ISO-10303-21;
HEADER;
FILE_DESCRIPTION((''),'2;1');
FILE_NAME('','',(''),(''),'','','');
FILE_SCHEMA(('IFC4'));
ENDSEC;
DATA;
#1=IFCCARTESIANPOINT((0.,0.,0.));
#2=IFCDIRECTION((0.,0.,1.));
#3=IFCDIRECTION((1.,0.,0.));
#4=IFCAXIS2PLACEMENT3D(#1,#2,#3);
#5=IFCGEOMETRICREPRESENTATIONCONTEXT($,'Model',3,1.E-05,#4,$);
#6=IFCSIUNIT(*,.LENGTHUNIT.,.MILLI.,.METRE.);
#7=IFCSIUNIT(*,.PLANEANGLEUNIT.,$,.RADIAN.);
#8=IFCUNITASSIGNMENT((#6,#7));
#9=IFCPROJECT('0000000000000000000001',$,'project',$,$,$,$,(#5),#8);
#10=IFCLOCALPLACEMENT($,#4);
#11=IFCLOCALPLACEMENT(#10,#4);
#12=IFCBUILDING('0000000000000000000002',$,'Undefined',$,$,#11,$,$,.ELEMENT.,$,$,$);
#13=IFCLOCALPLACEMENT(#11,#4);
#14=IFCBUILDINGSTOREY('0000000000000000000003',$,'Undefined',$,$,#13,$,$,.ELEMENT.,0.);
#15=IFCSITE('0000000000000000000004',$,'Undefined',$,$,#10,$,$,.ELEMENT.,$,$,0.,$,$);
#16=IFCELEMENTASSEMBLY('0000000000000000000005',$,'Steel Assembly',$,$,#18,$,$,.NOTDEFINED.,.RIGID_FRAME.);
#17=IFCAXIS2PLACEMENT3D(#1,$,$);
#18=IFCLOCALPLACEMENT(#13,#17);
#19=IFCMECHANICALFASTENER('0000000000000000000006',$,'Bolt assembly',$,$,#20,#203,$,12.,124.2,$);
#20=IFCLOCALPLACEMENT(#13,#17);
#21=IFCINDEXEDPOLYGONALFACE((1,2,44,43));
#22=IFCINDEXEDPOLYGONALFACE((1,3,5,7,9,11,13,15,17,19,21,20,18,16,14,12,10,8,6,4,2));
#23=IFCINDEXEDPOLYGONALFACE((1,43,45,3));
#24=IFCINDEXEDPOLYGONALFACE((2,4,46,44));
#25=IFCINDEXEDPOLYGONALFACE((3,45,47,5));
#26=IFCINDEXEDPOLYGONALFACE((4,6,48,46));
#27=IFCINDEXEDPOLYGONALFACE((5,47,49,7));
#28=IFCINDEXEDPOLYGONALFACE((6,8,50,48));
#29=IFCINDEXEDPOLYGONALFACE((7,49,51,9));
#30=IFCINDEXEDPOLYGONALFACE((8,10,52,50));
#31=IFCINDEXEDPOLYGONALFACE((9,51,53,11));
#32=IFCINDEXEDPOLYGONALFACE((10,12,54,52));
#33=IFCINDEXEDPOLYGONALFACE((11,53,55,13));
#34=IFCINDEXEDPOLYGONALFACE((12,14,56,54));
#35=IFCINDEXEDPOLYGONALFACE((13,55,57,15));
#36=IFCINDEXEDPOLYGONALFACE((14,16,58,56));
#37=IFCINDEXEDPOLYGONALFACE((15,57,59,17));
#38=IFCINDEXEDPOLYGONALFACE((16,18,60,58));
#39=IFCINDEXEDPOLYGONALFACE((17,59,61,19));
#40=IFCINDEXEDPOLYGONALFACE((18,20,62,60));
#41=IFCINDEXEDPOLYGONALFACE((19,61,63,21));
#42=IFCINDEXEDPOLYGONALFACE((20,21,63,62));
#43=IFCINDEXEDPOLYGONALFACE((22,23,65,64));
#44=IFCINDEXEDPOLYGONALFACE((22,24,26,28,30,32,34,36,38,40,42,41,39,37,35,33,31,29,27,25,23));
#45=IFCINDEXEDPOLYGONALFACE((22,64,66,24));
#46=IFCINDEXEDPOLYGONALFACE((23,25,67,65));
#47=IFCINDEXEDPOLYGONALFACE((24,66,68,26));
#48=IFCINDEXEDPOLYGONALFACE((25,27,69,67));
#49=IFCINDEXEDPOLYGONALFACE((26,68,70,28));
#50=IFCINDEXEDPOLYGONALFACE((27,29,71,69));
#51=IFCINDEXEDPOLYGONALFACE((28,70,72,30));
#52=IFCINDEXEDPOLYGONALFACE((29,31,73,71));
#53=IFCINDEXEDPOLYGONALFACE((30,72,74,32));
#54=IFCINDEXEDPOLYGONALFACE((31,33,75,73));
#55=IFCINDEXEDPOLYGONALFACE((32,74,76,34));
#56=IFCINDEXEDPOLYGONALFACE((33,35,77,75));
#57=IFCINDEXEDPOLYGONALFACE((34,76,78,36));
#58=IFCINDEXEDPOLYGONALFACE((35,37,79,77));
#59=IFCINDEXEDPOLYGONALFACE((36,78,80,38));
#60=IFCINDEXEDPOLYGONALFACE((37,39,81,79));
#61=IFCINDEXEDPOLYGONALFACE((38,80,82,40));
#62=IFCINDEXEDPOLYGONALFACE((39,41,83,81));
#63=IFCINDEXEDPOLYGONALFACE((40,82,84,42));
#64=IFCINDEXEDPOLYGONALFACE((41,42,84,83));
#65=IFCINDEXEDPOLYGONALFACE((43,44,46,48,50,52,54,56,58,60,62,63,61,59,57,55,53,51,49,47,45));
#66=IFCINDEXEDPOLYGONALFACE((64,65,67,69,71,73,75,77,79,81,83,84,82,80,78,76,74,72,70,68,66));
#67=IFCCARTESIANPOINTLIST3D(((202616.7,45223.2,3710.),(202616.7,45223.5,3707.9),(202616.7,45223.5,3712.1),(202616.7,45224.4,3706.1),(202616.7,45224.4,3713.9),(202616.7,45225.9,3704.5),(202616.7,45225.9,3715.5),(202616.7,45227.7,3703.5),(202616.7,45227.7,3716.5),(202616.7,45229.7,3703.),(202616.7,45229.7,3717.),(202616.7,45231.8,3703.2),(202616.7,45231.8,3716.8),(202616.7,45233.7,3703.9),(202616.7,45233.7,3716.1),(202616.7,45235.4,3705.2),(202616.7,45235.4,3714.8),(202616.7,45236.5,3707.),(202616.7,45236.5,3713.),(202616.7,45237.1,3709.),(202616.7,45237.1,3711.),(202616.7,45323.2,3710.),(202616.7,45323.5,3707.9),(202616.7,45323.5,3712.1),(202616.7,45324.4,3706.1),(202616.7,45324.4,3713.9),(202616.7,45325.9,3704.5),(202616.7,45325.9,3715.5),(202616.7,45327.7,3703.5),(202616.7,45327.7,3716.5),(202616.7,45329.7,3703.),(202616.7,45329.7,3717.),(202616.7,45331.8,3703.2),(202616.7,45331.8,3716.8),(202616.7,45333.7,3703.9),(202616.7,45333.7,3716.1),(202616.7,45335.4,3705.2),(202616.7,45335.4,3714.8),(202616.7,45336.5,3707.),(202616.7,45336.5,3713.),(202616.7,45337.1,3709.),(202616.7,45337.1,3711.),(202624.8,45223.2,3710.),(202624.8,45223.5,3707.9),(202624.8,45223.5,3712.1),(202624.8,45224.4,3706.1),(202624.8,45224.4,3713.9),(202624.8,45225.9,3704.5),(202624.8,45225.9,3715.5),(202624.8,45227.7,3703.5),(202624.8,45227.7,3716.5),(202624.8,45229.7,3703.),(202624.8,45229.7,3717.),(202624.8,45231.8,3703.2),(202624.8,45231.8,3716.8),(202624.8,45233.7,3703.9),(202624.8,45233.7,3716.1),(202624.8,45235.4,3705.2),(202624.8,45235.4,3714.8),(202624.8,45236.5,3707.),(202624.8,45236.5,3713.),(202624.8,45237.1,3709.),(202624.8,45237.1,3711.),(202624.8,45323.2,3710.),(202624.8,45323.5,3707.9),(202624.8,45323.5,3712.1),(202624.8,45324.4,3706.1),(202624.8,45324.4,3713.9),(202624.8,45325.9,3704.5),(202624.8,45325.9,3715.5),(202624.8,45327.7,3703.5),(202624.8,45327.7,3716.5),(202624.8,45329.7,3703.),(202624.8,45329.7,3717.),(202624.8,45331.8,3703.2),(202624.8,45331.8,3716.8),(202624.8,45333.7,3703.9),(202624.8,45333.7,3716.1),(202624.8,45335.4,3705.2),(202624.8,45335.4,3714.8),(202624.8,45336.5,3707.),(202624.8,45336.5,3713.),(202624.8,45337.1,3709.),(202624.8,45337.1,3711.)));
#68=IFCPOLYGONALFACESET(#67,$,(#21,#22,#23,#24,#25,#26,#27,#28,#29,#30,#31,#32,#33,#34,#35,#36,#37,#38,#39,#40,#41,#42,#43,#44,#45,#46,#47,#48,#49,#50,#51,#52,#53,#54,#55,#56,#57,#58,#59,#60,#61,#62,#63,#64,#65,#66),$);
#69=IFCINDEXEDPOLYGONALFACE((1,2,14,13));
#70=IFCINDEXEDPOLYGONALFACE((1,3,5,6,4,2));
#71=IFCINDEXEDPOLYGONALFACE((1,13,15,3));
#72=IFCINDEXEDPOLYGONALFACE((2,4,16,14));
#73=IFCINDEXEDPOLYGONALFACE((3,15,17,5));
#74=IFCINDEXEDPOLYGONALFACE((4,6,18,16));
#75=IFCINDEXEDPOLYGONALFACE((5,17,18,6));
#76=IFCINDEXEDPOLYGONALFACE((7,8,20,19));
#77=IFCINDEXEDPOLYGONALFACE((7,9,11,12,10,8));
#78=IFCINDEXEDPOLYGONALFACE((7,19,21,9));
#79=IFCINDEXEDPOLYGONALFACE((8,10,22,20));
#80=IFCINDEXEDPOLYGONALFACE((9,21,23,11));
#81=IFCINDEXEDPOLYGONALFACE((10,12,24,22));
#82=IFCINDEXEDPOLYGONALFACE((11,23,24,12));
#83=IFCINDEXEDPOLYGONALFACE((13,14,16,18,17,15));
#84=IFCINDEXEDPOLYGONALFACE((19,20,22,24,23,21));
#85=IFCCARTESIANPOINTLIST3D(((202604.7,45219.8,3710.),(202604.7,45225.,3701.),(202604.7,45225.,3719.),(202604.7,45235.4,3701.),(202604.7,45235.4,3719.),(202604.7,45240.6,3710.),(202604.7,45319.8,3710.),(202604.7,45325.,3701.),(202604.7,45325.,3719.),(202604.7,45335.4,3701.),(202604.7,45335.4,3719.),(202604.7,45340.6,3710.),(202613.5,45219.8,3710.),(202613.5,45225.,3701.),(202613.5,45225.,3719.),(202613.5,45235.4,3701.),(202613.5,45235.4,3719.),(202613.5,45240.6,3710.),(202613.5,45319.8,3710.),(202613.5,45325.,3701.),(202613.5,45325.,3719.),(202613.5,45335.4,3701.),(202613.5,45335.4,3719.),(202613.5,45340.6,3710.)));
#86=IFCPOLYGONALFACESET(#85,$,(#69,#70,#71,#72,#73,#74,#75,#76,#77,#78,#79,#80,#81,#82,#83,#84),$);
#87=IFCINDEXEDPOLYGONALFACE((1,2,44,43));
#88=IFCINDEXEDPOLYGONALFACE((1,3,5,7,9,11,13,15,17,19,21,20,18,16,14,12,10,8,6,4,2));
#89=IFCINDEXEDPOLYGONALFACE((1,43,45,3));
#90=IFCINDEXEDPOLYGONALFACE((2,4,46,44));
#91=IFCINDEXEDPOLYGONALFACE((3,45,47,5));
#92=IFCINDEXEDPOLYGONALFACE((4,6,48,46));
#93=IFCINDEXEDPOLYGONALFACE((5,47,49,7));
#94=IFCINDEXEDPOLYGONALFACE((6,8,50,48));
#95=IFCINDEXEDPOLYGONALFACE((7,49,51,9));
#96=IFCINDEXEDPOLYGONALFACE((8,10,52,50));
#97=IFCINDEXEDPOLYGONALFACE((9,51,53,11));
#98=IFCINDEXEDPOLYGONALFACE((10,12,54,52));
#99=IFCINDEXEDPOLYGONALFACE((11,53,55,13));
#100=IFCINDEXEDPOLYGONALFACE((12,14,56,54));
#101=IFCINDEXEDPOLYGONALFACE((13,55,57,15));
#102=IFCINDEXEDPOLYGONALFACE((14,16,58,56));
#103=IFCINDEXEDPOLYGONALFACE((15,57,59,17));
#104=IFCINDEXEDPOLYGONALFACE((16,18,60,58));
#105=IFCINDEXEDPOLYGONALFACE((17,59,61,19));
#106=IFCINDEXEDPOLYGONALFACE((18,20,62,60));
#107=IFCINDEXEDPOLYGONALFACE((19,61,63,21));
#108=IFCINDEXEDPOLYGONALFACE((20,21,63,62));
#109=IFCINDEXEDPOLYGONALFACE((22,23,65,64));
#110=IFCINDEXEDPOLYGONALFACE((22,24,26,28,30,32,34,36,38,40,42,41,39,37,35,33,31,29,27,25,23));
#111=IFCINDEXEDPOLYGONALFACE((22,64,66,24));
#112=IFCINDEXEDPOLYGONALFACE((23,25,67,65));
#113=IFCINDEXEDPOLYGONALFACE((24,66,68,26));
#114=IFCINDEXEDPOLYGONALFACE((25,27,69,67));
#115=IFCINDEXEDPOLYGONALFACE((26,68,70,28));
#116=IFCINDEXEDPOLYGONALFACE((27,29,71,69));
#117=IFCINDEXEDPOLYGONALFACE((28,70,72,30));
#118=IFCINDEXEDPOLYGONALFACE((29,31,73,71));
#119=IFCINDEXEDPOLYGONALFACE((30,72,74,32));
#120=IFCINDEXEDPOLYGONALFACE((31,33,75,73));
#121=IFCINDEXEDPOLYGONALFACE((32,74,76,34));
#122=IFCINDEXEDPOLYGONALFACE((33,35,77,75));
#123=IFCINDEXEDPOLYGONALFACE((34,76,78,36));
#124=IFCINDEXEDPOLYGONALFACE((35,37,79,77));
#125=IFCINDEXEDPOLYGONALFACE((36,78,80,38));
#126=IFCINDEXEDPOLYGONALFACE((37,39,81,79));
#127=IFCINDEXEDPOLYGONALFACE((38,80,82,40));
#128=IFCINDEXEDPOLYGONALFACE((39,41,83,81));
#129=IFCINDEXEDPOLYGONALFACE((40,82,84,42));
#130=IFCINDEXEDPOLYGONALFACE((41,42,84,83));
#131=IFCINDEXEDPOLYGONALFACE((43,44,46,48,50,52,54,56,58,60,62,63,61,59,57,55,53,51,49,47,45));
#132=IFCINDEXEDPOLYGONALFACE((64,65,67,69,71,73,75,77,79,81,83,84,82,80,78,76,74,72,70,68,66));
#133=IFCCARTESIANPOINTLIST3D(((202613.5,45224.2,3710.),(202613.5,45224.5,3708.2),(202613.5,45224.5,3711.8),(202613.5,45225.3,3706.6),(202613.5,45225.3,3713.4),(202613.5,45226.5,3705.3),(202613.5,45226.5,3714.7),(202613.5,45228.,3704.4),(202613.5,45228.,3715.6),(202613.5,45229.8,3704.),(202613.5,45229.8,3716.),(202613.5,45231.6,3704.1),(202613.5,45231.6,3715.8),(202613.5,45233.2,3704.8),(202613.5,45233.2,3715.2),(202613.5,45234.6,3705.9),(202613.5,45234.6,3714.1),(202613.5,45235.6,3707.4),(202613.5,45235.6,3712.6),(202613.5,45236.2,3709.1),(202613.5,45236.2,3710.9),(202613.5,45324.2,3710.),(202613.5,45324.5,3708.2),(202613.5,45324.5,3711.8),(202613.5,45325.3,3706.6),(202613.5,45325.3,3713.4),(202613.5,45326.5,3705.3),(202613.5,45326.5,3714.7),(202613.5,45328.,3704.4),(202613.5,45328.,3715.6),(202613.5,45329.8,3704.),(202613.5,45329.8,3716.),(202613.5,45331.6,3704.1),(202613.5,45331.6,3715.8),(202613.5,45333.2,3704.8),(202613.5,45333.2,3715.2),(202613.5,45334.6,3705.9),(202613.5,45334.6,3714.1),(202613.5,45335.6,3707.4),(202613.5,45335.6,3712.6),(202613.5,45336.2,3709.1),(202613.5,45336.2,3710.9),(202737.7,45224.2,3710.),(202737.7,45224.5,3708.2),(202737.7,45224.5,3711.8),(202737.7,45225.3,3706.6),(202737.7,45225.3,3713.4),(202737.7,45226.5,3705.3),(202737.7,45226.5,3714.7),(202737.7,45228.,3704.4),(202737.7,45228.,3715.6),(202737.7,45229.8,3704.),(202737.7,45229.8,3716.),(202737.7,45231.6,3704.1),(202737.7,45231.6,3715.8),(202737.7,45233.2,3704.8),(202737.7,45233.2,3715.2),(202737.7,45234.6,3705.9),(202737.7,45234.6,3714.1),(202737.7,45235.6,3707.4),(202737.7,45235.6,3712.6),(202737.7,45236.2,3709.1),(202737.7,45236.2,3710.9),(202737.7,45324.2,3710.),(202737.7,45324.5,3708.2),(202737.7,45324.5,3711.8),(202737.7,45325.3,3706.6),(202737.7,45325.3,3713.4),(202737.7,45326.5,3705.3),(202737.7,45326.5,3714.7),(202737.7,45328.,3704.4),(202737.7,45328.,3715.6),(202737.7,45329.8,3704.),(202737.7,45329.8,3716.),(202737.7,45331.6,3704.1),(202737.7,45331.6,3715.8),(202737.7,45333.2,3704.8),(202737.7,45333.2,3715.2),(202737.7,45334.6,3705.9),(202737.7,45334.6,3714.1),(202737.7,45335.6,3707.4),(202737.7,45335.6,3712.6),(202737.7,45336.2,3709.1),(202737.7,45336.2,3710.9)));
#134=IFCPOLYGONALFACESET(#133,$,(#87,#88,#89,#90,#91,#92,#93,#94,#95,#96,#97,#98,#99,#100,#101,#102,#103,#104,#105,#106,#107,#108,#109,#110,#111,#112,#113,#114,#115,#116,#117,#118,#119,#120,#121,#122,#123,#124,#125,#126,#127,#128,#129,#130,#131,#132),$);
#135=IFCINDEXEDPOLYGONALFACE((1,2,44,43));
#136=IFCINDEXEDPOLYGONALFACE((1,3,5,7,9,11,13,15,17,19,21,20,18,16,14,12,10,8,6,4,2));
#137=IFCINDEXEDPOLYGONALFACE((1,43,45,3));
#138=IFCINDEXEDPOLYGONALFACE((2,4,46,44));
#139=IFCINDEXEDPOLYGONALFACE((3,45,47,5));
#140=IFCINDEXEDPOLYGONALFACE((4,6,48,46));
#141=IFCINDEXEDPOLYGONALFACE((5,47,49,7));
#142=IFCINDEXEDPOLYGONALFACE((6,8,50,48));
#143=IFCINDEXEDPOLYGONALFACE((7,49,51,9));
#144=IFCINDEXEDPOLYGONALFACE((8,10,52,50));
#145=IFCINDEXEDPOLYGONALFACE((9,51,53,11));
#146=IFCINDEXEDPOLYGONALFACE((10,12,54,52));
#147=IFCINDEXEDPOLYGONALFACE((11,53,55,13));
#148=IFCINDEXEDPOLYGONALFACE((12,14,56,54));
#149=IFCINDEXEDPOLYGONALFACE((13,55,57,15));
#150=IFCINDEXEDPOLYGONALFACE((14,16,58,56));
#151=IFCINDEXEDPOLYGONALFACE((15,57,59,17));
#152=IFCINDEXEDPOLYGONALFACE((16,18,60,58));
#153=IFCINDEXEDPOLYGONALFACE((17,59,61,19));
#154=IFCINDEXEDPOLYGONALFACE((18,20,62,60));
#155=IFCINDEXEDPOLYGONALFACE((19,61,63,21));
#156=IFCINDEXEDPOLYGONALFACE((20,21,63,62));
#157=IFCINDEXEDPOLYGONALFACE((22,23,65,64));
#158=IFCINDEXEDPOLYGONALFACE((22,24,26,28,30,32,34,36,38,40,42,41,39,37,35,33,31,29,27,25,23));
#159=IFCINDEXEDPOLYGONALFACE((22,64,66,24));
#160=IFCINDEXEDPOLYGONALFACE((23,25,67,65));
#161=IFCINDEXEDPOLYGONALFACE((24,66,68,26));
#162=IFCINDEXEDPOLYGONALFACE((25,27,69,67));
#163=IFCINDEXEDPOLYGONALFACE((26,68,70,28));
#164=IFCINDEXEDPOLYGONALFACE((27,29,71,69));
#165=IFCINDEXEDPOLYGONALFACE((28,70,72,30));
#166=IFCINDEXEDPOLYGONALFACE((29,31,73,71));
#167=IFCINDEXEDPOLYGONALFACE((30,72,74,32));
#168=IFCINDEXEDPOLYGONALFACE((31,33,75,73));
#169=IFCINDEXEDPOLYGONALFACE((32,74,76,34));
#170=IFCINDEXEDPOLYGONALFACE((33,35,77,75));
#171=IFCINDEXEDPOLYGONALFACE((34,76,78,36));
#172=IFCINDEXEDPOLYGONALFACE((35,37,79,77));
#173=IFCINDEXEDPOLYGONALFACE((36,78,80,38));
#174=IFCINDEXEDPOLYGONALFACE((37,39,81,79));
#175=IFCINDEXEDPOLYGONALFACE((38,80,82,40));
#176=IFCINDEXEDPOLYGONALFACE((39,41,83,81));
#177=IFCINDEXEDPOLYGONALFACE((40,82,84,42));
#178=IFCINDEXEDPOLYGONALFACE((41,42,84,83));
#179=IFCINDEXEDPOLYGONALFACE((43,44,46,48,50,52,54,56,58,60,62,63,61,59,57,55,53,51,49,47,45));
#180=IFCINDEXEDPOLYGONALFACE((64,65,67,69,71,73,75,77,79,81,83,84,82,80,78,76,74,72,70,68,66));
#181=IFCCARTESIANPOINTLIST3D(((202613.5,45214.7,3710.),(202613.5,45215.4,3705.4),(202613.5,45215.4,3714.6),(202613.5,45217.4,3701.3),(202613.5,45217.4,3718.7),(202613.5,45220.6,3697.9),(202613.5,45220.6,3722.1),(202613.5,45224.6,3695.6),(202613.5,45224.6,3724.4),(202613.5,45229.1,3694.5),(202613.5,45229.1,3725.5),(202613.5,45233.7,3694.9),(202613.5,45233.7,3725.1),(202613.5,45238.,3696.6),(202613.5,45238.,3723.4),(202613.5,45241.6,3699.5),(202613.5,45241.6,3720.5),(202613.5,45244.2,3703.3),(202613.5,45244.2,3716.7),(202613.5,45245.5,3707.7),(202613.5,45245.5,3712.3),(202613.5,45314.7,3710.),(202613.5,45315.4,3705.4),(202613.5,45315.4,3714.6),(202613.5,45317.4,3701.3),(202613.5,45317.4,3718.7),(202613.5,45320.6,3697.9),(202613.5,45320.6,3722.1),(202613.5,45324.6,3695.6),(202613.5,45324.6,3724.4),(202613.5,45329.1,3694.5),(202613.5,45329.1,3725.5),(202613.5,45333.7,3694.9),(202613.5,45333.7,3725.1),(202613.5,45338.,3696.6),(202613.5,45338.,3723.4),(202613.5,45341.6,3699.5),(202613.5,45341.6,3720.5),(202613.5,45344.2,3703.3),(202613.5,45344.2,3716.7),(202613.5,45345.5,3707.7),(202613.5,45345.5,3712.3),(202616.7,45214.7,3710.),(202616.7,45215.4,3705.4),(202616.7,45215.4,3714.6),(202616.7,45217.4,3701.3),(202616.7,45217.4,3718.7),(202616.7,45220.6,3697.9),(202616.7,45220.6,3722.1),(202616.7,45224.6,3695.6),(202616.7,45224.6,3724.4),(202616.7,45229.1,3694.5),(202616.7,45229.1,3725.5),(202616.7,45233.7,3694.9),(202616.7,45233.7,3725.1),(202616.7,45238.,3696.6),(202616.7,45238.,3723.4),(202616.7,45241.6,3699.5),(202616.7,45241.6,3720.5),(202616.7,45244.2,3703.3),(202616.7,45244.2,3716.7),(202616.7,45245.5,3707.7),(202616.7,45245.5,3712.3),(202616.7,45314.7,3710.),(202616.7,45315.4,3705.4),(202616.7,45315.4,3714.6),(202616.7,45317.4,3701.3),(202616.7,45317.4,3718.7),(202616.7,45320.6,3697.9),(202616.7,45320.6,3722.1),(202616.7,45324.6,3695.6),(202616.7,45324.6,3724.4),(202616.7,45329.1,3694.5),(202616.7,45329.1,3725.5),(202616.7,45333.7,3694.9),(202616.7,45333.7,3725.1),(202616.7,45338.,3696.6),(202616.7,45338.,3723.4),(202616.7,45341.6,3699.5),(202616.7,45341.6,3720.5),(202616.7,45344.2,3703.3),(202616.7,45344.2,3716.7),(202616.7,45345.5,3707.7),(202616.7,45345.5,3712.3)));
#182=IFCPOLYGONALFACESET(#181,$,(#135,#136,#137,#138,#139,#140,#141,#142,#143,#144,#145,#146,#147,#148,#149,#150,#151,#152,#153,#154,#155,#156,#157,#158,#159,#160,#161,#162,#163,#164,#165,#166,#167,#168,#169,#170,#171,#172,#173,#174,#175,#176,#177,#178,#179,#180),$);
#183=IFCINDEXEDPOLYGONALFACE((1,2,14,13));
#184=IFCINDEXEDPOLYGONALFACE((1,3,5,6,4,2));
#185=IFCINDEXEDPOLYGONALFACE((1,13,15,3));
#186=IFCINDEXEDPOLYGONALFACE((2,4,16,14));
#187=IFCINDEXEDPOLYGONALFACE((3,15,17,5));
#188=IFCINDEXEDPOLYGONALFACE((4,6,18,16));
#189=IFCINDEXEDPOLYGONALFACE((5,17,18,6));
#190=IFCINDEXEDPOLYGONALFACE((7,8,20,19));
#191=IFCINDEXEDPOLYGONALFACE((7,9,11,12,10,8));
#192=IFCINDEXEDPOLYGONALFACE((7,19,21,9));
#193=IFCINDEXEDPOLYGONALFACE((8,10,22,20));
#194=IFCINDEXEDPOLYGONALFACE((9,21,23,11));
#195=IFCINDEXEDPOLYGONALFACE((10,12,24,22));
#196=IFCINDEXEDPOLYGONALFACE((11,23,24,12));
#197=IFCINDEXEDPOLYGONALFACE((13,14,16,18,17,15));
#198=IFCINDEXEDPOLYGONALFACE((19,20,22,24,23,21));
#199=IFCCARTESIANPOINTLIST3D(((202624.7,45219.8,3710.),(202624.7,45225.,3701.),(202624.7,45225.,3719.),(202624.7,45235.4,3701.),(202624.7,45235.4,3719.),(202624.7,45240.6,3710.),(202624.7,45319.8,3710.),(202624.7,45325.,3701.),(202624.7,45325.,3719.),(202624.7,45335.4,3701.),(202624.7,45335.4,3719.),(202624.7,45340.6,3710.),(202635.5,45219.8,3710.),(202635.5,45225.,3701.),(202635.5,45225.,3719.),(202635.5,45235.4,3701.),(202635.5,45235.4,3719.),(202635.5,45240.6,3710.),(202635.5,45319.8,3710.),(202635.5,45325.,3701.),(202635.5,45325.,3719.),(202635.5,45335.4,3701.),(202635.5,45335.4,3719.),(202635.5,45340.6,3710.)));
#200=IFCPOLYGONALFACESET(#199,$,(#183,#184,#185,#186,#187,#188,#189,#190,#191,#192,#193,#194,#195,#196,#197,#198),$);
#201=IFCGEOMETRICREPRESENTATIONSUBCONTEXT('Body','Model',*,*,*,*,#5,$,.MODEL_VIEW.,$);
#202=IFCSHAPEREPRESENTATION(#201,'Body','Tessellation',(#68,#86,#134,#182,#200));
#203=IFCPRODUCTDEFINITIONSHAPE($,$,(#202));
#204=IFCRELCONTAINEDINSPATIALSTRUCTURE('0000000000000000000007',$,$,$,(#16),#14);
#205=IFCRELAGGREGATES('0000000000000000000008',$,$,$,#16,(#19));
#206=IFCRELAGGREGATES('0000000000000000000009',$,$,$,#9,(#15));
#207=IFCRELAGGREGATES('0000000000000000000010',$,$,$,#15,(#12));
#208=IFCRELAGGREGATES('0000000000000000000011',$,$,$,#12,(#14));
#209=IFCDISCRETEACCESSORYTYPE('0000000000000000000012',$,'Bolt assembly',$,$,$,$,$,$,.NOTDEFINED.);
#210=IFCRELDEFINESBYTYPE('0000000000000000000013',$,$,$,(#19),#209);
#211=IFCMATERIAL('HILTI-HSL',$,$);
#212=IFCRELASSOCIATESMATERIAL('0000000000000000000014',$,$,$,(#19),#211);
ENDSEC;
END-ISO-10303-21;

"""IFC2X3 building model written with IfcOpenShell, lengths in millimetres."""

from ifc_helpers import new_model, si_unit, frame, origin_with_axes, origin_2d_with_axis, place, context, subcontext, project, spatial, polyline, circle, outline, extrude, source, transform, mapped, material, type_object, element, aggregate, save


model = new_model("IFC2X3")

# Units and contexts
model_context = context("Model", 3, precision=1e-05, world=origin_with_axes())
body_context = subcontext(model_context, "Body", "Model", "MODEL_VIEW")
ifc_project = project(units=[si_unit("LENGTHUNIT", "METRE", prefix="MILLI"), si_unit("PLANEANGLEUNIT", "RADIAN")], contexts=[model_context])

# Site, building, storey
site_placement = place(None, origin_with_axes())
site = spatial("IfcSite", under=ifc_project, at=site_placement, Name="Undefined", CompositionType="ELEMENT", RefElevation=0.0)
building_placement = place(site_placement, origin_with_axes())
building = spatial("IfcBuilding", under=site, at=building_placement, Name="Undefined", CompositionType="ELEMENT")
storey_placement = place(building_placement, origin_with_axes())
storey = spatial("IfcBuildingStorey", under=building, at=storey_placement, Name="Undefined", CompositionType="ELEMENT", Elevation=0.0)

# Element assembly
assembly_1_placement = place(storey_placement, origin_with_axes())
assembly_1 = element("IfcElementAssembly", 1, at=assembly_1_placement, inside=storey, Name="Steel Assembly", AssemblyPlace="NOTDEFINED", PredefinedType="RIGID_FRAME")

# Shared definitions
discrete_accessory_type_1 = type_object("IfcDiscreteAccessoryType", Name="Bolt assembly")

# Mechanical fastener
ifc_material_1 = material(Name="HILTI-HSL")
shared_shape_1 = source(origin_with_axes(), body_context, "Body", "SweptSolid", [
    extrude(circle(Radius=7.0, at=origin_2d_with_axis()), frame((0.0, 0.0, 0.0), z_axis=(0.0, 1.0, 0.0), x_axis=(1.0, 0.0, 0.0)), (0.0, 0.0, 1.0), 8.1),
    extrude(outline(polyline([(10.4, 0.0), (5.2, 9.0), (-5.2, 9.0), (-10.4, 0.0), (-5.2, -9.0), (5.2, -9.0), (10.4, 0.0)])), frame((0.0, -12.0, 0.0), z_axis=(0.0, 1.0, 0.0), x_axis=(1.0, 0.0, 0.0)), (0.0, 0.0, 1.0), 8.8),
    extrude(circle(Radius=6.0, at=origin_2d_with_axis()), frame((0.0, -3.2, 0.0), z_axis=(0.0, 1.0, 0.0), x_axis=(1.0, 0.0, 0.0)), (0.0, 0.0, 1.0), 124.2),
    extrude(circle(Radius=15.5, at=origin_2d_with_axis()), frame((0.0, -3.2, 0.0), z_axis=(0.0, 1.0, 0.0), x_axis=(1.0, 0.0, 0.0)), (0.0, 0.0, 1.0), 3.2),
    extrude(outline(polyline([(10.4, 0.0), (5.2, 9.0), (-5.2, 9.0), (-10.4, 0.0), (-5.2, -9.0), (5.2, -9.0), (10.4, 0.0)])), frame((0.0, 8.0, 0.0), z_axis=(0.0, 1.0, 0.0), x_axis=(1.0, 0.0, 0.0)), (0.0, 0.0, 1.0), 10.8),
])
mechanical_fastener_1_placement = place(assembly_1_placement, frame((202616.7, 45380.2, 3620.0), z_axis=(0.0, 0.0, 1.0), x_axis=(0.0, -1.0, 0.0)))
mechanical_fastener_1 = element("IfcMechanicalFastener", 2, at=mechanical_fastener_1_placement, type_object=discrete_accessory_type_1, material=ifc_material_1, Name="Bolt assembly", NominalDiameter=12.0, NominalLength=124.2, context=body_context, shape_type="MappedRepresentation", body=[
    mapped(shared_shape_1, transform((150.0, 0.0, 90.0))),
    mapped(shared_shape_1, transform((50.0, 0.0, 90.0))),
])
aggregate(assembly_1, [mechanical_fastener_1])

save(model, "model.ifc")
